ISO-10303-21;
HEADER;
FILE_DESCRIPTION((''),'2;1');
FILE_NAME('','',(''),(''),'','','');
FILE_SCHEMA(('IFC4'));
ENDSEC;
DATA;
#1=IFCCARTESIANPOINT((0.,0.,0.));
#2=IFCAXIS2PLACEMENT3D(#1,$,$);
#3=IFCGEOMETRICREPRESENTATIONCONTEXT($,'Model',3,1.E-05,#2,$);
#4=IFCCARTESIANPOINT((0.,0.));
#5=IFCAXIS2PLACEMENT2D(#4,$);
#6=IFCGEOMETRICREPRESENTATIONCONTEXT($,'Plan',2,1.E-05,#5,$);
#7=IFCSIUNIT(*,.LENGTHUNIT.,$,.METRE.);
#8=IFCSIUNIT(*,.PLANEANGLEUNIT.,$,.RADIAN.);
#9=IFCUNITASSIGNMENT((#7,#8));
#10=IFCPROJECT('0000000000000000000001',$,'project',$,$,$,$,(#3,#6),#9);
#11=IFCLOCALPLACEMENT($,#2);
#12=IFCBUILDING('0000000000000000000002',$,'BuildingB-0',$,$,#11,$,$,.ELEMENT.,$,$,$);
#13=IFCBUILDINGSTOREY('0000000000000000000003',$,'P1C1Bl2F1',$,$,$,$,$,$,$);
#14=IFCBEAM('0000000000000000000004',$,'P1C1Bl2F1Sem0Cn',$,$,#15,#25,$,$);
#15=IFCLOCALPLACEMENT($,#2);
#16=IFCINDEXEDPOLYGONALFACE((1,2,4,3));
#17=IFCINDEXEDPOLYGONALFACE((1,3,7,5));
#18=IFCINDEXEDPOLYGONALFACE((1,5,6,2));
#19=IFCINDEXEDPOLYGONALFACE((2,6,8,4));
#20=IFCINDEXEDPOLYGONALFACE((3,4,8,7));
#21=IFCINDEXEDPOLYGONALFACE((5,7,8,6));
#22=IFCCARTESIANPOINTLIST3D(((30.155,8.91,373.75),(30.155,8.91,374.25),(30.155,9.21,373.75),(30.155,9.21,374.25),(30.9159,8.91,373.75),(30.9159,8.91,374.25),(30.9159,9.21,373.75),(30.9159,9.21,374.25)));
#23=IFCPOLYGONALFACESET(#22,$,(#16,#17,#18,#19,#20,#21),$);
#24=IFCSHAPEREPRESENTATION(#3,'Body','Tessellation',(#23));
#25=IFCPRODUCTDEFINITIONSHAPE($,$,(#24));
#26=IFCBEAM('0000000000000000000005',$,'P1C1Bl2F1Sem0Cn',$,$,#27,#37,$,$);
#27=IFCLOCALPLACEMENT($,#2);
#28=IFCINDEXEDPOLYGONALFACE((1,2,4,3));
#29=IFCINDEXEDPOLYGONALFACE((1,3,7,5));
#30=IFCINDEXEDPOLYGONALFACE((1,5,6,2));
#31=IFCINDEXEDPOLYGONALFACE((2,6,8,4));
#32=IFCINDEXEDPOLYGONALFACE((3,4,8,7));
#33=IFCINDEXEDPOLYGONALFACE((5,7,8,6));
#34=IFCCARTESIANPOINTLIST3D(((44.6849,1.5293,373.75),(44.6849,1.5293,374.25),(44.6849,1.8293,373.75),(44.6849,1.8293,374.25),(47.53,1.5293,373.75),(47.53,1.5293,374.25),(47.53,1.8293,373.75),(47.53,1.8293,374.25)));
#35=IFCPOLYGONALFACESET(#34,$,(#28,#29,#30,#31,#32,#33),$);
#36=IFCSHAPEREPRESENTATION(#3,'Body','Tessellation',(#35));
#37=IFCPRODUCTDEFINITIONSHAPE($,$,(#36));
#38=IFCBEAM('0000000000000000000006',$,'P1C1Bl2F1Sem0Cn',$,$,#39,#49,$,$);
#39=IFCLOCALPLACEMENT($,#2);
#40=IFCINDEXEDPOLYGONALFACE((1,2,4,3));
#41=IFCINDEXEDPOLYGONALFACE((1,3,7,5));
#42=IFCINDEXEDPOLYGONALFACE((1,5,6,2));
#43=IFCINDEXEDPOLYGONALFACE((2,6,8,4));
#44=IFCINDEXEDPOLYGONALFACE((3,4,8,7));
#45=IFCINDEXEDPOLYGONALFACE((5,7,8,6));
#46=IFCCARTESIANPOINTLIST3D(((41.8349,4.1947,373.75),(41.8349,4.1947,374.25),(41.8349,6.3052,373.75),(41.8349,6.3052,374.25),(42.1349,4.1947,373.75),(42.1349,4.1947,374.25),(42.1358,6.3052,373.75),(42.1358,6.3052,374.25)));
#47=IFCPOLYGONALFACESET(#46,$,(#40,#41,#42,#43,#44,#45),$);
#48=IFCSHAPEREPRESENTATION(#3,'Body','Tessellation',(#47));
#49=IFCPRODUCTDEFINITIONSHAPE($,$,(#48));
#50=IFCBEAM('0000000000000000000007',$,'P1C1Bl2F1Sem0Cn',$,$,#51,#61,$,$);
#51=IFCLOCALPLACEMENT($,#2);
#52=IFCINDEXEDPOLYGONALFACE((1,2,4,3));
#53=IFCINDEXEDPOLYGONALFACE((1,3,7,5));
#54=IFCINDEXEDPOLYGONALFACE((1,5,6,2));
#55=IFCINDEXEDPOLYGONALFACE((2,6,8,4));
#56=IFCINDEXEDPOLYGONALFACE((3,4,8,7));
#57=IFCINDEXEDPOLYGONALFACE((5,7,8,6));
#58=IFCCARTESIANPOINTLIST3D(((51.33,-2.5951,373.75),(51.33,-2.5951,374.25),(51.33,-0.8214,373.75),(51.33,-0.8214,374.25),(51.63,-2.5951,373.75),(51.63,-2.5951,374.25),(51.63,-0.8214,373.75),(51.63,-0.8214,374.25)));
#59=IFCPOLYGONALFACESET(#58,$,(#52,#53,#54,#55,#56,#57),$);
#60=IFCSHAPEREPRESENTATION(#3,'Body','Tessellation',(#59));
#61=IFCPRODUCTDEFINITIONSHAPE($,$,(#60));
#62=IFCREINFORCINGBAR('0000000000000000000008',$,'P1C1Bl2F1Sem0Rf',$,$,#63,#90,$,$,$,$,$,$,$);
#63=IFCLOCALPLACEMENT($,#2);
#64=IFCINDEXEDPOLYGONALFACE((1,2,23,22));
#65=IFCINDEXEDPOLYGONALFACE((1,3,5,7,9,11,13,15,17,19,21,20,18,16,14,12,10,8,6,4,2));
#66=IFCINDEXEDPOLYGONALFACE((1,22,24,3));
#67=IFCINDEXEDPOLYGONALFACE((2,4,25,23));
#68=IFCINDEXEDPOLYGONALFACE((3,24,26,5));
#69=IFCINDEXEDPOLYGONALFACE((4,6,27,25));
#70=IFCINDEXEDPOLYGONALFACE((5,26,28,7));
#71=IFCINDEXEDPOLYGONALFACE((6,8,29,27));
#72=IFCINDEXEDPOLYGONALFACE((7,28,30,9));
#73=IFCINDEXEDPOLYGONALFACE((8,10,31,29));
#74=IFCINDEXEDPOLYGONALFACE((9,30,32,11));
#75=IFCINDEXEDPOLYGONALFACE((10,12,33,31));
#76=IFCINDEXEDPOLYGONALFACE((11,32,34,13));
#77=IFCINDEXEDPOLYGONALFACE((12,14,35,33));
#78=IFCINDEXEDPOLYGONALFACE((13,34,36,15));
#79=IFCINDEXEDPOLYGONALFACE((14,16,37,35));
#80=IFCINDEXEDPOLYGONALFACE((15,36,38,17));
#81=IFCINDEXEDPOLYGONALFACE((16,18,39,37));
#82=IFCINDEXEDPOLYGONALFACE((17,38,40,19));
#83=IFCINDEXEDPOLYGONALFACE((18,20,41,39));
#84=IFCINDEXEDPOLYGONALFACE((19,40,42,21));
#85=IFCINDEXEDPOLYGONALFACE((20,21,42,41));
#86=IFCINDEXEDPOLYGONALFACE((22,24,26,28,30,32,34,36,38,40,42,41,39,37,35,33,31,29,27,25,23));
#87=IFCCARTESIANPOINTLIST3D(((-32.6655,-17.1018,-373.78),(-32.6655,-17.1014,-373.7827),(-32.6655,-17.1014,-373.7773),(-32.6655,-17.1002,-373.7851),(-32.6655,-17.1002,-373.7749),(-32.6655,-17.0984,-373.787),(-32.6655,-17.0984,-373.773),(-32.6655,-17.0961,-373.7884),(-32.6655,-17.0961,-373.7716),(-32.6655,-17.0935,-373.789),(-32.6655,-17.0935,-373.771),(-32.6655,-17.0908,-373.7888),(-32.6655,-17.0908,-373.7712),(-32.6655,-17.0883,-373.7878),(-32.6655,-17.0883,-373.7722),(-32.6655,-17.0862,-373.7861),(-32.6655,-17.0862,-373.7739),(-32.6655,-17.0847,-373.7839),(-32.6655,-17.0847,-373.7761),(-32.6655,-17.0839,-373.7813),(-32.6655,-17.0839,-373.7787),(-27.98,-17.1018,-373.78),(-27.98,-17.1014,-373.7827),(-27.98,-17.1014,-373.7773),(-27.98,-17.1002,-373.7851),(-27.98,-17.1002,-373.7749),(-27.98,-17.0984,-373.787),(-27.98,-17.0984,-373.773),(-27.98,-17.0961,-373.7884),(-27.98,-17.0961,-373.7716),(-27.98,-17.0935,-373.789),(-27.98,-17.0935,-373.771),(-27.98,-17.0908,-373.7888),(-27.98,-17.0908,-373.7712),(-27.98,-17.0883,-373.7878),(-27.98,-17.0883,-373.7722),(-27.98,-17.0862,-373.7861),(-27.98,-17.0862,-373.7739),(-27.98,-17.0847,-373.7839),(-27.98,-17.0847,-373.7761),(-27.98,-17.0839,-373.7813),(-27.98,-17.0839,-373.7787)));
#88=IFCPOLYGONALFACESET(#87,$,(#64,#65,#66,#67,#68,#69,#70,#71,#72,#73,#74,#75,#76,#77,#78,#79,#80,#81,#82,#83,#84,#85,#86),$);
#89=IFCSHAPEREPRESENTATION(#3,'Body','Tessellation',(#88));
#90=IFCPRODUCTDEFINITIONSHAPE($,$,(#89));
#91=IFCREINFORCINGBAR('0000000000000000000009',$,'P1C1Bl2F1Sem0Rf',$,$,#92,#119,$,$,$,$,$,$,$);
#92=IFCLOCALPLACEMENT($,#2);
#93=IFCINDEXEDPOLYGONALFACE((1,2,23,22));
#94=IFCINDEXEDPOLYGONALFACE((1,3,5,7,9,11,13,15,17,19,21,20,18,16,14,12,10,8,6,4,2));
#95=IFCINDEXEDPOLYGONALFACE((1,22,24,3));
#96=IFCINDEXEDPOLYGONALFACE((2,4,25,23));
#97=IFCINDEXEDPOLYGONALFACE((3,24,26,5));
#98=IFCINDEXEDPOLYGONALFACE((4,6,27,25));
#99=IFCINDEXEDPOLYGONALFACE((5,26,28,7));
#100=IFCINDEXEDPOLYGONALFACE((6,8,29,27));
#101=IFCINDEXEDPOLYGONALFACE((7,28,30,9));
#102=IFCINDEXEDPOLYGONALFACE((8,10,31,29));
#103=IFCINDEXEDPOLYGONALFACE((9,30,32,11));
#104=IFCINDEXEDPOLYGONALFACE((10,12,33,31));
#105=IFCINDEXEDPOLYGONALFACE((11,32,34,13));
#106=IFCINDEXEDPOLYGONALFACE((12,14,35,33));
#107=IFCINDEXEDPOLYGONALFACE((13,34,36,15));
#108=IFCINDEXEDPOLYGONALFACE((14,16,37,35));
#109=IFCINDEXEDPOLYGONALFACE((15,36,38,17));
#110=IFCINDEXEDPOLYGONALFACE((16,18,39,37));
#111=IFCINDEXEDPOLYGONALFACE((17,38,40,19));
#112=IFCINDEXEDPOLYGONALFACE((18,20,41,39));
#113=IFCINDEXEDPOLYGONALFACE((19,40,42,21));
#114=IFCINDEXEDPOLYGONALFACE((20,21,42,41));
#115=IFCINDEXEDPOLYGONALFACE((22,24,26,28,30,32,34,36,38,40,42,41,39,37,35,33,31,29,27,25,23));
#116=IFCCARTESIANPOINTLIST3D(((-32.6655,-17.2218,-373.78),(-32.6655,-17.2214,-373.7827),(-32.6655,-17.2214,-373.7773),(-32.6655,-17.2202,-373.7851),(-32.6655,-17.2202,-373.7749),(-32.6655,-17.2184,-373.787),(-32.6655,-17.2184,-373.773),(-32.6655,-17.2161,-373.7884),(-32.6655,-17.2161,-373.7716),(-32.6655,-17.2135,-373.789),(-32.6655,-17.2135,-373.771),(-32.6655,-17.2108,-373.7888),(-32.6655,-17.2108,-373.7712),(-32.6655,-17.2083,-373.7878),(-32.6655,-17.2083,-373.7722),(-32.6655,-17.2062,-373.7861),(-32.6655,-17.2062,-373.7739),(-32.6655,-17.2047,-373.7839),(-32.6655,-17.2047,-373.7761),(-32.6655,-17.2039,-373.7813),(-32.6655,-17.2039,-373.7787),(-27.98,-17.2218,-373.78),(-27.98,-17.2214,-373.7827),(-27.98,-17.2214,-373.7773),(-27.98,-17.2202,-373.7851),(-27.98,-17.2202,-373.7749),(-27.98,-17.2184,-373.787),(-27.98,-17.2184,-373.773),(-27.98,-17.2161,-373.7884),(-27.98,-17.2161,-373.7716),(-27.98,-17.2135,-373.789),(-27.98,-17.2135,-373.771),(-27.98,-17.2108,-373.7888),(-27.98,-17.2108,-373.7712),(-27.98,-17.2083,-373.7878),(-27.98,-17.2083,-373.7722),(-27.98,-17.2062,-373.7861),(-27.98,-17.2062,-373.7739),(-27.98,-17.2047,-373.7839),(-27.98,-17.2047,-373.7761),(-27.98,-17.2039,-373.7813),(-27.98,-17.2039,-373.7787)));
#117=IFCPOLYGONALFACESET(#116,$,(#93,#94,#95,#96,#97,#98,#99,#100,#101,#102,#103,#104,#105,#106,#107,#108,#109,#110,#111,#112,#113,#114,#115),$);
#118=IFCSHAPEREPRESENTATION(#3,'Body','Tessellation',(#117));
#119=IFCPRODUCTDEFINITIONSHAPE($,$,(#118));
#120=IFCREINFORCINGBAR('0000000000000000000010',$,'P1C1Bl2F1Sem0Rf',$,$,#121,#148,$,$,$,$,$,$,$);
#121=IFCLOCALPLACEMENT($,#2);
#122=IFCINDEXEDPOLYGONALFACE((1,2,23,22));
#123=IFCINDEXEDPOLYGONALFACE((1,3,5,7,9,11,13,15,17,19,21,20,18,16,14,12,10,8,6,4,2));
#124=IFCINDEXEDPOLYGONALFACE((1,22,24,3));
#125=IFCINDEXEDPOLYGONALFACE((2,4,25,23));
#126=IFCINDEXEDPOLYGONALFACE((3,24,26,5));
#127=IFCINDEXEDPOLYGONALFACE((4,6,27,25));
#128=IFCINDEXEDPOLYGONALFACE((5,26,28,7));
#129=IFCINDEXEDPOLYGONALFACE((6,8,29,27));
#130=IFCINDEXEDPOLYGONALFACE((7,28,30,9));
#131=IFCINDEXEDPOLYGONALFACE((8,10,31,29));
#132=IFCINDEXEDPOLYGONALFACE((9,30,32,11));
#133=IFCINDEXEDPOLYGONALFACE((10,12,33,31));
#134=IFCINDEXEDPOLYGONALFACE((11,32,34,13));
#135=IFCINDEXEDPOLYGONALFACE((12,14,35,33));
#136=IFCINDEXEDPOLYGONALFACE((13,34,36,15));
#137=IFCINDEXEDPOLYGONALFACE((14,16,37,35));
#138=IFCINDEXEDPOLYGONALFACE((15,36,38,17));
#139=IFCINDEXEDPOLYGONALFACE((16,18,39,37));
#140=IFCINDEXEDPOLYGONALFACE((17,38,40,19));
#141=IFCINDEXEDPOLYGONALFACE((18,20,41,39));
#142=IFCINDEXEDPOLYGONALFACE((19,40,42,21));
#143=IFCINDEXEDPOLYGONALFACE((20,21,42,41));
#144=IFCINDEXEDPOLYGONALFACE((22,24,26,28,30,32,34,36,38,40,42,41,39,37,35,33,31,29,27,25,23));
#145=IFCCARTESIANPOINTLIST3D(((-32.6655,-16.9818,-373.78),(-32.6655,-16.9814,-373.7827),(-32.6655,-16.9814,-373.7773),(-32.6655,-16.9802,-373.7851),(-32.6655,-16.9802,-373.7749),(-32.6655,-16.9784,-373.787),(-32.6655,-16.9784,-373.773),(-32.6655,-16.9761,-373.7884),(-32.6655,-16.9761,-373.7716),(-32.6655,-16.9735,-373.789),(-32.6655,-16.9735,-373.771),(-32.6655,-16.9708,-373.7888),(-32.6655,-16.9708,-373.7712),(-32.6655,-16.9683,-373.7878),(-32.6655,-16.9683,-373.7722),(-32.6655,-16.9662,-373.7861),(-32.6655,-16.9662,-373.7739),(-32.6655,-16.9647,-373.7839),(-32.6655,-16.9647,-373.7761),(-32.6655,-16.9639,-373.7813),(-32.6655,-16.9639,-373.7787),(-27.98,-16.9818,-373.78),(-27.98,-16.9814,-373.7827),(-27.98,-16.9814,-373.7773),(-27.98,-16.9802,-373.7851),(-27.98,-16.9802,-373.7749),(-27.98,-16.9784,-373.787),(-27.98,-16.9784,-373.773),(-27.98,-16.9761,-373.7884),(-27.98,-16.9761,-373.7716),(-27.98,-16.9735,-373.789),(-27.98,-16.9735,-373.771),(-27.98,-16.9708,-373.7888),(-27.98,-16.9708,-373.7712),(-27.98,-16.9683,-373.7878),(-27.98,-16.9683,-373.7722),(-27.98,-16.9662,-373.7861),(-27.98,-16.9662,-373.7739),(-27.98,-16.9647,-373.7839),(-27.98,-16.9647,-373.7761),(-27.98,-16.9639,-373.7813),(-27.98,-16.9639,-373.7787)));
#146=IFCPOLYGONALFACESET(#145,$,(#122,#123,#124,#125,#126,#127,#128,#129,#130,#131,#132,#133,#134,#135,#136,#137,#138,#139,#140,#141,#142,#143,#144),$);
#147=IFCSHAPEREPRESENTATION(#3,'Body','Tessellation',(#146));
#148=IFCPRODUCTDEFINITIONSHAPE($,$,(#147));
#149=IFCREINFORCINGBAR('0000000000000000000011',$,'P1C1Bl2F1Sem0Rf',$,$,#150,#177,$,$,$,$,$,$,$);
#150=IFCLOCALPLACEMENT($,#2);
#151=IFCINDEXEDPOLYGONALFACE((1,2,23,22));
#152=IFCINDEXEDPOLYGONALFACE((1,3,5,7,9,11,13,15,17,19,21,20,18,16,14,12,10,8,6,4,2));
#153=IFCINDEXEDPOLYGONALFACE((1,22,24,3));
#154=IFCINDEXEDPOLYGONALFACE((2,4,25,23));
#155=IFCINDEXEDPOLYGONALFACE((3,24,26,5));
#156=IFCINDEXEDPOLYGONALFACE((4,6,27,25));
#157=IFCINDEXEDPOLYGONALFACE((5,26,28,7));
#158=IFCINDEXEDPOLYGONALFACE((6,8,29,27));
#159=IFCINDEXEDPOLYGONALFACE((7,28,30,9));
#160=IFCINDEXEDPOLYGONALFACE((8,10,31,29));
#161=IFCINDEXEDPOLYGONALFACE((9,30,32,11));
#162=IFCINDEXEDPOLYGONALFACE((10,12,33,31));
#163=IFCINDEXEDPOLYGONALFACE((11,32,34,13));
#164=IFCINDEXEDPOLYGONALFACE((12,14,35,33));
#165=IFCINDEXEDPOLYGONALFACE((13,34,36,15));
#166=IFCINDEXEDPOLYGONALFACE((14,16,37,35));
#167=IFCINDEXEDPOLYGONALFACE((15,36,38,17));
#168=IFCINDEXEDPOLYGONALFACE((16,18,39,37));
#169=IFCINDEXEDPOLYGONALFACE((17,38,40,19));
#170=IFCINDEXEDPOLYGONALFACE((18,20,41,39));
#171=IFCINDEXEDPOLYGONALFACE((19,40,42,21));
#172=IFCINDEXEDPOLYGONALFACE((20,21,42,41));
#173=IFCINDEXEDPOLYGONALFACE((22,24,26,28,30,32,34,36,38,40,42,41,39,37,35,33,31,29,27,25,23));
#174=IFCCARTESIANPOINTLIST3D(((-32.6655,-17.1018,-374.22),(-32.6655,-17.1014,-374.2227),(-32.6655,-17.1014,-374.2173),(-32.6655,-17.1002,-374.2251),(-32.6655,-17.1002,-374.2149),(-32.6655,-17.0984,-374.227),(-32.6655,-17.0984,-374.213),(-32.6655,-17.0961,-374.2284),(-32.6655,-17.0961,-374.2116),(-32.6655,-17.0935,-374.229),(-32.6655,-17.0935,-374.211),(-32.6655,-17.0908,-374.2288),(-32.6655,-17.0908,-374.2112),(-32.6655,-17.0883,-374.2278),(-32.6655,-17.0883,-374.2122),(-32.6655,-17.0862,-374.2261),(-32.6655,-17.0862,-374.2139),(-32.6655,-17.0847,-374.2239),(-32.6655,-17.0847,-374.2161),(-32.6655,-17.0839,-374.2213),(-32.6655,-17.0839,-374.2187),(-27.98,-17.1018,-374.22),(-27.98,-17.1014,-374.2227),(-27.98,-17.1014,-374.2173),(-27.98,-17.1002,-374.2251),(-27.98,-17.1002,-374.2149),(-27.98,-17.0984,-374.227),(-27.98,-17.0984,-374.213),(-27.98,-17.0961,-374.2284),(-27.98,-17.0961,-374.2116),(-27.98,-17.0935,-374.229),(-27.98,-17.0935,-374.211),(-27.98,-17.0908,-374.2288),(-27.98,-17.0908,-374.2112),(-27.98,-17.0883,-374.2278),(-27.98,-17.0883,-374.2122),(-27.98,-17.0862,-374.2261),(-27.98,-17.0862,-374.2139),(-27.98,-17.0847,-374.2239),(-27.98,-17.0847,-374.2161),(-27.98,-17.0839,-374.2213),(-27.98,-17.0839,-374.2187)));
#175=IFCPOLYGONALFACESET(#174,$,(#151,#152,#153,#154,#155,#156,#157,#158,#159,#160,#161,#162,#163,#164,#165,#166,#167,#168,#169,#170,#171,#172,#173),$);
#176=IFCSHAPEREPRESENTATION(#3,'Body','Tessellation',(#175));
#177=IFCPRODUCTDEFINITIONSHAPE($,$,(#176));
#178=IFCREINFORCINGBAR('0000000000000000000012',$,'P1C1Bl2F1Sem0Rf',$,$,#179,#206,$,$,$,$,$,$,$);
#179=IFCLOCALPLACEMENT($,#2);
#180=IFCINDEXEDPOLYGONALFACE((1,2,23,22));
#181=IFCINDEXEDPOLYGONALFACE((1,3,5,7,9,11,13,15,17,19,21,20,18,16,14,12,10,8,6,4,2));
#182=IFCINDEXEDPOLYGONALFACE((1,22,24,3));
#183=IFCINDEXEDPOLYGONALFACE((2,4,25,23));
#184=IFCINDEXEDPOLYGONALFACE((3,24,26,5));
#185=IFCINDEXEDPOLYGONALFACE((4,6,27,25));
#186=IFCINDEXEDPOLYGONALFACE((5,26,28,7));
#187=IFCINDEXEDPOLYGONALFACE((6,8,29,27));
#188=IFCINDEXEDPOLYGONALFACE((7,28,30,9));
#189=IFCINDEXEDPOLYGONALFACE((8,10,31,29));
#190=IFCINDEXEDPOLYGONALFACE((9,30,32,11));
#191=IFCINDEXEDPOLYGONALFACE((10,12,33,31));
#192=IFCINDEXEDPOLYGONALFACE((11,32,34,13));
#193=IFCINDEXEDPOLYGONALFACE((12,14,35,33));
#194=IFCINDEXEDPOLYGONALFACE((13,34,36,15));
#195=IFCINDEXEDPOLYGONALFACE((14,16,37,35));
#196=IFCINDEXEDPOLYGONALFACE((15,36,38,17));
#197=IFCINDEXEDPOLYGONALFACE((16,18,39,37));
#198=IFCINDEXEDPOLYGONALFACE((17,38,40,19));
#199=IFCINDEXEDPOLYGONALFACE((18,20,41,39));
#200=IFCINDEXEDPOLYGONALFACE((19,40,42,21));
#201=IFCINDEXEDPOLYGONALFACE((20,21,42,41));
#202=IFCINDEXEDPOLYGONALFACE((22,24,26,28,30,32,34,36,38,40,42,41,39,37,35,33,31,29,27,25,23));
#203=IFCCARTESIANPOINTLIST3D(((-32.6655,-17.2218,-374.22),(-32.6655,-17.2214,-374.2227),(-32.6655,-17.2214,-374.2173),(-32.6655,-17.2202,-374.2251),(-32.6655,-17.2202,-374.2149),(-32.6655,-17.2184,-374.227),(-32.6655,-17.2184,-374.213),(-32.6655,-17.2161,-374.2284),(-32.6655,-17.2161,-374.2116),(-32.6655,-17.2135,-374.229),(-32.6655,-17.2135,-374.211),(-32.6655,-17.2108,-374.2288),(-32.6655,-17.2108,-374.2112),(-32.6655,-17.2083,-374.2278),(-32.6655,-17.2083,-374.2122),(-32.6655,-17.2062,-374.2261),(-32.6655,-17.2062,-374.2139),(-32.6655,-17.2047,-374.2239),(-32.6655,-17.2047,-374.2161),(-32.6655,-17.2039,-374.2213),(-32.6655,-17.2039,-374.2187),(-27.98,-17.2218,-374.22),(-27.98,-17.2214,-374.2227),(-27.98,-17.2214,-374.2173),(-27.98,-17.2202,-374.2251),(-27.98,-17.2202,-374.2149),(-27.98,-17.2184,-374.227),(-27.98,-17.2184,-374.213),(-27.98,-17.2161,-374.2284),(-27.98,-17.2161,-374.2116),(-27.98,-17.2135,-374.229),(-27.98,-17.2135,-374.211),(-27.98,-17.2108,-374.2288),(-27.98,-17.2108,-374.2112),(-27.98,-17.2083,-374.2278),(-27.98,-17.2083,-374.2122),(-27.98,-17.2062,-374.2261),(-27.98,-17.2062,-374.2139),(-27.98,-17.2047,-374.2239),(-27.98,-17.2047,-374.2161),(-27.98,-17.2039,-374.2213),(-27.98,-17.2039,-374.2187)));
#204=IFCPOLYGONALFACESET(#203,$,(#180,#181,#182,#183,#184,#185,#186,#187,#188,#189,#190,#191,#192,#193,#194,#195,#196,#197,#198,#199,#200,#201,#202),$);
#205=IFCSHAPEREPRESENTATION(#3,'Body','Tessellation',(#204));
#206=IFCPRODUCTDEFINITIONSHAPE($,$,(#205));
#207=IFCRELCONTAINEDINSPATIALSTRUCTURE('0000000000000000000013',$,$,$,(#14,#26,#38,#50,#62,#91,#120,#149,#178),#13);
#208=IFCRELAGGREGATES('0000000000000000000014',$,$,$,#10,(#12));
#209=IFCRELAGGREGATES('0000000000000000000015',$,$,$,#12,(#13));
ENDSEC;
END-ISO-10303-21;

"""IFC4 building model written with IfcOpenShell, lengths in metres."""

from ifc_helpers import new_model, entity, si_unit, origin, origin_2d, place, context, project, spatial, polyline, outline, extrude, element, save


model = new_model("IFC4")

# Units and contexts
model_context = context("Model", 3, precision=1e-05, world=origin())
plan_context = context("Plan", 2, precision=1e-05, world=origin_2d())
ifc_project = project(units=[si_unit("LENGTHUNIT", "METRE"), si_unit("PLANEANGLEUNIT", "RADIAN")], contexts=[model_context, plan_context])

# Building, storey
building_placement = place(None, origin())
building = spatial("IfcBuilding", under=ifc_project, at=building_placement, Name="BuildingB-0", CompositionType="ELEMENT")
storey = spatial("IfcBuildingStorey", under=building, Name="P1C1Bl2F1")

# Beams
element("IfcBeam", 1, inside=storey, Name="P1C1Bl2F1Sem0Cn", context=model_context, shape_type="SweptSolid", body=[
    extrude(outline(polyline([(30.155, 8.91, 373.75), (30.9159, 8.91, 373.75), (30.9159, 9.21, 373.75), (30.155, 9.21, 373.75), (30.155, 8.91, 373.75)])), None, (0.0, 0.0, 1.0), 0.5),
])
element("IfcBeam", 2, inside=storey, Name="P1C1Bl2F1Sem0Cn", context=model_context, shape_type="SweptSolid", body=[
    extrude(outline(polyline([(44.6849, 1.5293, 373.75), (44.6849, 1.8293, 373.75), (47.53, 1.8293, 373.75), (47.53, 1.5293, 373.75), (44.6849, 1.5293, 373.75)])), None, (0.0, 0.0, 1.0), 0.5),
])
element("IfcBeam", 3, inside=storey, Name="P1C1Bl2F1Sem0Cn", context=model_context, shape_type="SweptSolid", body=[
    extrude(outline(polyline([(41.8349, 4.1947, 373.75), (42.1349, 4.1947, 373.75), (42.1358, 6.3052, 373.75), (41.8349, 6.3052, 373.75), (41.8349, 4.1947, 373.75)])), None, (0.0, 0.0, 1.0), 0.5),
])
element("IfcBeam", 4, inside=storey, Name="P1C1Bl2F1Sem0Cn", context=model_context, shape_type="SweptSolid", body=[
    extrude(outline(polyline([(51.33, -2.5951, 373.75), (51.63, -2.5951, 373.75), (51.63, -0.8214, 373.75), (51.33, -0.8214, 373.75), (51.33, -2.5951, 373.75)])), None, (0.0, 0.0, 1.0), 0.5),
])

# Reinforcing bars
element("IfcReinforcingBar", 5, inside=storey, Name="P1C1Bl2F1Sem0Rf", context=model_context, shape_type="SweptSolid", body=[
    entity("IfcSurfaceCurveSweptAreaSolid", entity("IfcCircleProfileDef", "AREA", None, None, 0.009), None, entity("IfcPolyline", [entity("IfcCartesianPoint", [32.6655, 17.0928, 373.78]), entity("IfcCartesianPoint", [27.98, 17.0928, 373.78])]), None, None, entity("IfcPlane", entity("IfcAxis2Placement3D", entity("IfcCartesianPoint", [32.6655, 17.0928, 373.78]), entity("IfcDirection", [0.0, 0.0, 1.0]), entity("IfcDirection", [1.0, 0.0, 0.0])))),
])
element("IfcReinforcingBar", 6, inside=storey, Name="P1C1Bl2F1Sem0Rf", context=model_context, shape_type="SweptSolid", body=[
    entity("IfcSurfaceCurveSweptAreaSolid", entity("IfcCircleProfileDef", "AREA", None, None, 0.009), None, entity("IfcPolyline", [entity("IfcCartesianPoint", [32.6655, 17.2128, 373.78]), entity("IfcCartesianPoint", [27.98, 17.2128, 373.78])]), None, None, entity("IfcPlane", entity("IfcAxis2Placement3D", entity("IfcCartesianPoint", [32.6655, 17.2128, 373.78]), entity("IfcDirection", [0.0, 0.0, 1.0]), entity("IfcDirection", [1.0, 0.0, 0.0])))),
])
element("IfcReinforcingBar", 7, inside=storey, Name="P1C1Bl2F1Sem0Rf", context=model_context, shape_type="SweptSolid", body=[
    entity("IfcSurfaceCurveSweptAreaSolid", entity("IfcCircleProfileDef", "AREA", None, None, 0.009), None, entity("IfcPolyline", [entity("IfcCartesianPoint", [32.6655, 16.9728, 373.78]), entity("IfcCartesianPoint", [27.98, 16.9728, 373.78])]), None, None, entity("IfcPlane", entity("IfcAxis2Placement3D", entity("IfcCartesianPoint", [32.6655, 16.9728, 373.78]), entity("IfcDirection", [0.0, 0.0, 1.0]), entity("IfcDirection", [1.0, 0.0, 0.0])))),
])
element("IfcReinforcingBar", 8, inside=storey, Name="P1C1Bl2F1Sem0Rf", context=model_context, shape_type="SweptSolid", body=[
    entity("IfcSurfaceCurveSweptAreaSolid", entity("IfcCircleProfileDef", "AREA", None, None, 0.009), None, entity("IfcPolyline", [entity("IfcCartesianPoint", [32.6655, 17.0928, 374.22]), entity("IfcCartesianPoint", [27.98, 17.0928, 374.22])]), None, None, entity("IfcPlane", entity("IfcAxis2Placement3D", entity("IfcCartesianPoint", [32.6655, 17.0928, 374.22]), entity("IfcDirection", [0.0, 0.0, 1.0]), entity("IfcDirection", [1.0, 0.0, 0.0])))),
])
element("IfcReinforcingBar", 9, inside=storey, Name="P1C1Bl2F1Sem0Rf", context=model_context, shape_type="SweptSolid", body=[
    entity("IfcSurfaceCurveSweptAreaSolid", entity("IfcCircleProfileDef", "AREA", None, None, 0.009), None, entity("IfcPolyline", [entity("IfcCartesianPoint", [32.6655, 17.2128, 374.22]), entity("IfcCartesianPoint", [27.98, 17.2128, 374.22])]), None, None, entity("IfcPlane", entity("IfcAxis2Placement3D", entity("IfcCartesianPoint", [32.6655, 17.2128, 374.22]), entity("IfcDirection", [0.0, 0.0, 1.0]), entity("IfcDirection", [1.0, 0.0, 0.0])))),
])

save(model, "model.ifc")
